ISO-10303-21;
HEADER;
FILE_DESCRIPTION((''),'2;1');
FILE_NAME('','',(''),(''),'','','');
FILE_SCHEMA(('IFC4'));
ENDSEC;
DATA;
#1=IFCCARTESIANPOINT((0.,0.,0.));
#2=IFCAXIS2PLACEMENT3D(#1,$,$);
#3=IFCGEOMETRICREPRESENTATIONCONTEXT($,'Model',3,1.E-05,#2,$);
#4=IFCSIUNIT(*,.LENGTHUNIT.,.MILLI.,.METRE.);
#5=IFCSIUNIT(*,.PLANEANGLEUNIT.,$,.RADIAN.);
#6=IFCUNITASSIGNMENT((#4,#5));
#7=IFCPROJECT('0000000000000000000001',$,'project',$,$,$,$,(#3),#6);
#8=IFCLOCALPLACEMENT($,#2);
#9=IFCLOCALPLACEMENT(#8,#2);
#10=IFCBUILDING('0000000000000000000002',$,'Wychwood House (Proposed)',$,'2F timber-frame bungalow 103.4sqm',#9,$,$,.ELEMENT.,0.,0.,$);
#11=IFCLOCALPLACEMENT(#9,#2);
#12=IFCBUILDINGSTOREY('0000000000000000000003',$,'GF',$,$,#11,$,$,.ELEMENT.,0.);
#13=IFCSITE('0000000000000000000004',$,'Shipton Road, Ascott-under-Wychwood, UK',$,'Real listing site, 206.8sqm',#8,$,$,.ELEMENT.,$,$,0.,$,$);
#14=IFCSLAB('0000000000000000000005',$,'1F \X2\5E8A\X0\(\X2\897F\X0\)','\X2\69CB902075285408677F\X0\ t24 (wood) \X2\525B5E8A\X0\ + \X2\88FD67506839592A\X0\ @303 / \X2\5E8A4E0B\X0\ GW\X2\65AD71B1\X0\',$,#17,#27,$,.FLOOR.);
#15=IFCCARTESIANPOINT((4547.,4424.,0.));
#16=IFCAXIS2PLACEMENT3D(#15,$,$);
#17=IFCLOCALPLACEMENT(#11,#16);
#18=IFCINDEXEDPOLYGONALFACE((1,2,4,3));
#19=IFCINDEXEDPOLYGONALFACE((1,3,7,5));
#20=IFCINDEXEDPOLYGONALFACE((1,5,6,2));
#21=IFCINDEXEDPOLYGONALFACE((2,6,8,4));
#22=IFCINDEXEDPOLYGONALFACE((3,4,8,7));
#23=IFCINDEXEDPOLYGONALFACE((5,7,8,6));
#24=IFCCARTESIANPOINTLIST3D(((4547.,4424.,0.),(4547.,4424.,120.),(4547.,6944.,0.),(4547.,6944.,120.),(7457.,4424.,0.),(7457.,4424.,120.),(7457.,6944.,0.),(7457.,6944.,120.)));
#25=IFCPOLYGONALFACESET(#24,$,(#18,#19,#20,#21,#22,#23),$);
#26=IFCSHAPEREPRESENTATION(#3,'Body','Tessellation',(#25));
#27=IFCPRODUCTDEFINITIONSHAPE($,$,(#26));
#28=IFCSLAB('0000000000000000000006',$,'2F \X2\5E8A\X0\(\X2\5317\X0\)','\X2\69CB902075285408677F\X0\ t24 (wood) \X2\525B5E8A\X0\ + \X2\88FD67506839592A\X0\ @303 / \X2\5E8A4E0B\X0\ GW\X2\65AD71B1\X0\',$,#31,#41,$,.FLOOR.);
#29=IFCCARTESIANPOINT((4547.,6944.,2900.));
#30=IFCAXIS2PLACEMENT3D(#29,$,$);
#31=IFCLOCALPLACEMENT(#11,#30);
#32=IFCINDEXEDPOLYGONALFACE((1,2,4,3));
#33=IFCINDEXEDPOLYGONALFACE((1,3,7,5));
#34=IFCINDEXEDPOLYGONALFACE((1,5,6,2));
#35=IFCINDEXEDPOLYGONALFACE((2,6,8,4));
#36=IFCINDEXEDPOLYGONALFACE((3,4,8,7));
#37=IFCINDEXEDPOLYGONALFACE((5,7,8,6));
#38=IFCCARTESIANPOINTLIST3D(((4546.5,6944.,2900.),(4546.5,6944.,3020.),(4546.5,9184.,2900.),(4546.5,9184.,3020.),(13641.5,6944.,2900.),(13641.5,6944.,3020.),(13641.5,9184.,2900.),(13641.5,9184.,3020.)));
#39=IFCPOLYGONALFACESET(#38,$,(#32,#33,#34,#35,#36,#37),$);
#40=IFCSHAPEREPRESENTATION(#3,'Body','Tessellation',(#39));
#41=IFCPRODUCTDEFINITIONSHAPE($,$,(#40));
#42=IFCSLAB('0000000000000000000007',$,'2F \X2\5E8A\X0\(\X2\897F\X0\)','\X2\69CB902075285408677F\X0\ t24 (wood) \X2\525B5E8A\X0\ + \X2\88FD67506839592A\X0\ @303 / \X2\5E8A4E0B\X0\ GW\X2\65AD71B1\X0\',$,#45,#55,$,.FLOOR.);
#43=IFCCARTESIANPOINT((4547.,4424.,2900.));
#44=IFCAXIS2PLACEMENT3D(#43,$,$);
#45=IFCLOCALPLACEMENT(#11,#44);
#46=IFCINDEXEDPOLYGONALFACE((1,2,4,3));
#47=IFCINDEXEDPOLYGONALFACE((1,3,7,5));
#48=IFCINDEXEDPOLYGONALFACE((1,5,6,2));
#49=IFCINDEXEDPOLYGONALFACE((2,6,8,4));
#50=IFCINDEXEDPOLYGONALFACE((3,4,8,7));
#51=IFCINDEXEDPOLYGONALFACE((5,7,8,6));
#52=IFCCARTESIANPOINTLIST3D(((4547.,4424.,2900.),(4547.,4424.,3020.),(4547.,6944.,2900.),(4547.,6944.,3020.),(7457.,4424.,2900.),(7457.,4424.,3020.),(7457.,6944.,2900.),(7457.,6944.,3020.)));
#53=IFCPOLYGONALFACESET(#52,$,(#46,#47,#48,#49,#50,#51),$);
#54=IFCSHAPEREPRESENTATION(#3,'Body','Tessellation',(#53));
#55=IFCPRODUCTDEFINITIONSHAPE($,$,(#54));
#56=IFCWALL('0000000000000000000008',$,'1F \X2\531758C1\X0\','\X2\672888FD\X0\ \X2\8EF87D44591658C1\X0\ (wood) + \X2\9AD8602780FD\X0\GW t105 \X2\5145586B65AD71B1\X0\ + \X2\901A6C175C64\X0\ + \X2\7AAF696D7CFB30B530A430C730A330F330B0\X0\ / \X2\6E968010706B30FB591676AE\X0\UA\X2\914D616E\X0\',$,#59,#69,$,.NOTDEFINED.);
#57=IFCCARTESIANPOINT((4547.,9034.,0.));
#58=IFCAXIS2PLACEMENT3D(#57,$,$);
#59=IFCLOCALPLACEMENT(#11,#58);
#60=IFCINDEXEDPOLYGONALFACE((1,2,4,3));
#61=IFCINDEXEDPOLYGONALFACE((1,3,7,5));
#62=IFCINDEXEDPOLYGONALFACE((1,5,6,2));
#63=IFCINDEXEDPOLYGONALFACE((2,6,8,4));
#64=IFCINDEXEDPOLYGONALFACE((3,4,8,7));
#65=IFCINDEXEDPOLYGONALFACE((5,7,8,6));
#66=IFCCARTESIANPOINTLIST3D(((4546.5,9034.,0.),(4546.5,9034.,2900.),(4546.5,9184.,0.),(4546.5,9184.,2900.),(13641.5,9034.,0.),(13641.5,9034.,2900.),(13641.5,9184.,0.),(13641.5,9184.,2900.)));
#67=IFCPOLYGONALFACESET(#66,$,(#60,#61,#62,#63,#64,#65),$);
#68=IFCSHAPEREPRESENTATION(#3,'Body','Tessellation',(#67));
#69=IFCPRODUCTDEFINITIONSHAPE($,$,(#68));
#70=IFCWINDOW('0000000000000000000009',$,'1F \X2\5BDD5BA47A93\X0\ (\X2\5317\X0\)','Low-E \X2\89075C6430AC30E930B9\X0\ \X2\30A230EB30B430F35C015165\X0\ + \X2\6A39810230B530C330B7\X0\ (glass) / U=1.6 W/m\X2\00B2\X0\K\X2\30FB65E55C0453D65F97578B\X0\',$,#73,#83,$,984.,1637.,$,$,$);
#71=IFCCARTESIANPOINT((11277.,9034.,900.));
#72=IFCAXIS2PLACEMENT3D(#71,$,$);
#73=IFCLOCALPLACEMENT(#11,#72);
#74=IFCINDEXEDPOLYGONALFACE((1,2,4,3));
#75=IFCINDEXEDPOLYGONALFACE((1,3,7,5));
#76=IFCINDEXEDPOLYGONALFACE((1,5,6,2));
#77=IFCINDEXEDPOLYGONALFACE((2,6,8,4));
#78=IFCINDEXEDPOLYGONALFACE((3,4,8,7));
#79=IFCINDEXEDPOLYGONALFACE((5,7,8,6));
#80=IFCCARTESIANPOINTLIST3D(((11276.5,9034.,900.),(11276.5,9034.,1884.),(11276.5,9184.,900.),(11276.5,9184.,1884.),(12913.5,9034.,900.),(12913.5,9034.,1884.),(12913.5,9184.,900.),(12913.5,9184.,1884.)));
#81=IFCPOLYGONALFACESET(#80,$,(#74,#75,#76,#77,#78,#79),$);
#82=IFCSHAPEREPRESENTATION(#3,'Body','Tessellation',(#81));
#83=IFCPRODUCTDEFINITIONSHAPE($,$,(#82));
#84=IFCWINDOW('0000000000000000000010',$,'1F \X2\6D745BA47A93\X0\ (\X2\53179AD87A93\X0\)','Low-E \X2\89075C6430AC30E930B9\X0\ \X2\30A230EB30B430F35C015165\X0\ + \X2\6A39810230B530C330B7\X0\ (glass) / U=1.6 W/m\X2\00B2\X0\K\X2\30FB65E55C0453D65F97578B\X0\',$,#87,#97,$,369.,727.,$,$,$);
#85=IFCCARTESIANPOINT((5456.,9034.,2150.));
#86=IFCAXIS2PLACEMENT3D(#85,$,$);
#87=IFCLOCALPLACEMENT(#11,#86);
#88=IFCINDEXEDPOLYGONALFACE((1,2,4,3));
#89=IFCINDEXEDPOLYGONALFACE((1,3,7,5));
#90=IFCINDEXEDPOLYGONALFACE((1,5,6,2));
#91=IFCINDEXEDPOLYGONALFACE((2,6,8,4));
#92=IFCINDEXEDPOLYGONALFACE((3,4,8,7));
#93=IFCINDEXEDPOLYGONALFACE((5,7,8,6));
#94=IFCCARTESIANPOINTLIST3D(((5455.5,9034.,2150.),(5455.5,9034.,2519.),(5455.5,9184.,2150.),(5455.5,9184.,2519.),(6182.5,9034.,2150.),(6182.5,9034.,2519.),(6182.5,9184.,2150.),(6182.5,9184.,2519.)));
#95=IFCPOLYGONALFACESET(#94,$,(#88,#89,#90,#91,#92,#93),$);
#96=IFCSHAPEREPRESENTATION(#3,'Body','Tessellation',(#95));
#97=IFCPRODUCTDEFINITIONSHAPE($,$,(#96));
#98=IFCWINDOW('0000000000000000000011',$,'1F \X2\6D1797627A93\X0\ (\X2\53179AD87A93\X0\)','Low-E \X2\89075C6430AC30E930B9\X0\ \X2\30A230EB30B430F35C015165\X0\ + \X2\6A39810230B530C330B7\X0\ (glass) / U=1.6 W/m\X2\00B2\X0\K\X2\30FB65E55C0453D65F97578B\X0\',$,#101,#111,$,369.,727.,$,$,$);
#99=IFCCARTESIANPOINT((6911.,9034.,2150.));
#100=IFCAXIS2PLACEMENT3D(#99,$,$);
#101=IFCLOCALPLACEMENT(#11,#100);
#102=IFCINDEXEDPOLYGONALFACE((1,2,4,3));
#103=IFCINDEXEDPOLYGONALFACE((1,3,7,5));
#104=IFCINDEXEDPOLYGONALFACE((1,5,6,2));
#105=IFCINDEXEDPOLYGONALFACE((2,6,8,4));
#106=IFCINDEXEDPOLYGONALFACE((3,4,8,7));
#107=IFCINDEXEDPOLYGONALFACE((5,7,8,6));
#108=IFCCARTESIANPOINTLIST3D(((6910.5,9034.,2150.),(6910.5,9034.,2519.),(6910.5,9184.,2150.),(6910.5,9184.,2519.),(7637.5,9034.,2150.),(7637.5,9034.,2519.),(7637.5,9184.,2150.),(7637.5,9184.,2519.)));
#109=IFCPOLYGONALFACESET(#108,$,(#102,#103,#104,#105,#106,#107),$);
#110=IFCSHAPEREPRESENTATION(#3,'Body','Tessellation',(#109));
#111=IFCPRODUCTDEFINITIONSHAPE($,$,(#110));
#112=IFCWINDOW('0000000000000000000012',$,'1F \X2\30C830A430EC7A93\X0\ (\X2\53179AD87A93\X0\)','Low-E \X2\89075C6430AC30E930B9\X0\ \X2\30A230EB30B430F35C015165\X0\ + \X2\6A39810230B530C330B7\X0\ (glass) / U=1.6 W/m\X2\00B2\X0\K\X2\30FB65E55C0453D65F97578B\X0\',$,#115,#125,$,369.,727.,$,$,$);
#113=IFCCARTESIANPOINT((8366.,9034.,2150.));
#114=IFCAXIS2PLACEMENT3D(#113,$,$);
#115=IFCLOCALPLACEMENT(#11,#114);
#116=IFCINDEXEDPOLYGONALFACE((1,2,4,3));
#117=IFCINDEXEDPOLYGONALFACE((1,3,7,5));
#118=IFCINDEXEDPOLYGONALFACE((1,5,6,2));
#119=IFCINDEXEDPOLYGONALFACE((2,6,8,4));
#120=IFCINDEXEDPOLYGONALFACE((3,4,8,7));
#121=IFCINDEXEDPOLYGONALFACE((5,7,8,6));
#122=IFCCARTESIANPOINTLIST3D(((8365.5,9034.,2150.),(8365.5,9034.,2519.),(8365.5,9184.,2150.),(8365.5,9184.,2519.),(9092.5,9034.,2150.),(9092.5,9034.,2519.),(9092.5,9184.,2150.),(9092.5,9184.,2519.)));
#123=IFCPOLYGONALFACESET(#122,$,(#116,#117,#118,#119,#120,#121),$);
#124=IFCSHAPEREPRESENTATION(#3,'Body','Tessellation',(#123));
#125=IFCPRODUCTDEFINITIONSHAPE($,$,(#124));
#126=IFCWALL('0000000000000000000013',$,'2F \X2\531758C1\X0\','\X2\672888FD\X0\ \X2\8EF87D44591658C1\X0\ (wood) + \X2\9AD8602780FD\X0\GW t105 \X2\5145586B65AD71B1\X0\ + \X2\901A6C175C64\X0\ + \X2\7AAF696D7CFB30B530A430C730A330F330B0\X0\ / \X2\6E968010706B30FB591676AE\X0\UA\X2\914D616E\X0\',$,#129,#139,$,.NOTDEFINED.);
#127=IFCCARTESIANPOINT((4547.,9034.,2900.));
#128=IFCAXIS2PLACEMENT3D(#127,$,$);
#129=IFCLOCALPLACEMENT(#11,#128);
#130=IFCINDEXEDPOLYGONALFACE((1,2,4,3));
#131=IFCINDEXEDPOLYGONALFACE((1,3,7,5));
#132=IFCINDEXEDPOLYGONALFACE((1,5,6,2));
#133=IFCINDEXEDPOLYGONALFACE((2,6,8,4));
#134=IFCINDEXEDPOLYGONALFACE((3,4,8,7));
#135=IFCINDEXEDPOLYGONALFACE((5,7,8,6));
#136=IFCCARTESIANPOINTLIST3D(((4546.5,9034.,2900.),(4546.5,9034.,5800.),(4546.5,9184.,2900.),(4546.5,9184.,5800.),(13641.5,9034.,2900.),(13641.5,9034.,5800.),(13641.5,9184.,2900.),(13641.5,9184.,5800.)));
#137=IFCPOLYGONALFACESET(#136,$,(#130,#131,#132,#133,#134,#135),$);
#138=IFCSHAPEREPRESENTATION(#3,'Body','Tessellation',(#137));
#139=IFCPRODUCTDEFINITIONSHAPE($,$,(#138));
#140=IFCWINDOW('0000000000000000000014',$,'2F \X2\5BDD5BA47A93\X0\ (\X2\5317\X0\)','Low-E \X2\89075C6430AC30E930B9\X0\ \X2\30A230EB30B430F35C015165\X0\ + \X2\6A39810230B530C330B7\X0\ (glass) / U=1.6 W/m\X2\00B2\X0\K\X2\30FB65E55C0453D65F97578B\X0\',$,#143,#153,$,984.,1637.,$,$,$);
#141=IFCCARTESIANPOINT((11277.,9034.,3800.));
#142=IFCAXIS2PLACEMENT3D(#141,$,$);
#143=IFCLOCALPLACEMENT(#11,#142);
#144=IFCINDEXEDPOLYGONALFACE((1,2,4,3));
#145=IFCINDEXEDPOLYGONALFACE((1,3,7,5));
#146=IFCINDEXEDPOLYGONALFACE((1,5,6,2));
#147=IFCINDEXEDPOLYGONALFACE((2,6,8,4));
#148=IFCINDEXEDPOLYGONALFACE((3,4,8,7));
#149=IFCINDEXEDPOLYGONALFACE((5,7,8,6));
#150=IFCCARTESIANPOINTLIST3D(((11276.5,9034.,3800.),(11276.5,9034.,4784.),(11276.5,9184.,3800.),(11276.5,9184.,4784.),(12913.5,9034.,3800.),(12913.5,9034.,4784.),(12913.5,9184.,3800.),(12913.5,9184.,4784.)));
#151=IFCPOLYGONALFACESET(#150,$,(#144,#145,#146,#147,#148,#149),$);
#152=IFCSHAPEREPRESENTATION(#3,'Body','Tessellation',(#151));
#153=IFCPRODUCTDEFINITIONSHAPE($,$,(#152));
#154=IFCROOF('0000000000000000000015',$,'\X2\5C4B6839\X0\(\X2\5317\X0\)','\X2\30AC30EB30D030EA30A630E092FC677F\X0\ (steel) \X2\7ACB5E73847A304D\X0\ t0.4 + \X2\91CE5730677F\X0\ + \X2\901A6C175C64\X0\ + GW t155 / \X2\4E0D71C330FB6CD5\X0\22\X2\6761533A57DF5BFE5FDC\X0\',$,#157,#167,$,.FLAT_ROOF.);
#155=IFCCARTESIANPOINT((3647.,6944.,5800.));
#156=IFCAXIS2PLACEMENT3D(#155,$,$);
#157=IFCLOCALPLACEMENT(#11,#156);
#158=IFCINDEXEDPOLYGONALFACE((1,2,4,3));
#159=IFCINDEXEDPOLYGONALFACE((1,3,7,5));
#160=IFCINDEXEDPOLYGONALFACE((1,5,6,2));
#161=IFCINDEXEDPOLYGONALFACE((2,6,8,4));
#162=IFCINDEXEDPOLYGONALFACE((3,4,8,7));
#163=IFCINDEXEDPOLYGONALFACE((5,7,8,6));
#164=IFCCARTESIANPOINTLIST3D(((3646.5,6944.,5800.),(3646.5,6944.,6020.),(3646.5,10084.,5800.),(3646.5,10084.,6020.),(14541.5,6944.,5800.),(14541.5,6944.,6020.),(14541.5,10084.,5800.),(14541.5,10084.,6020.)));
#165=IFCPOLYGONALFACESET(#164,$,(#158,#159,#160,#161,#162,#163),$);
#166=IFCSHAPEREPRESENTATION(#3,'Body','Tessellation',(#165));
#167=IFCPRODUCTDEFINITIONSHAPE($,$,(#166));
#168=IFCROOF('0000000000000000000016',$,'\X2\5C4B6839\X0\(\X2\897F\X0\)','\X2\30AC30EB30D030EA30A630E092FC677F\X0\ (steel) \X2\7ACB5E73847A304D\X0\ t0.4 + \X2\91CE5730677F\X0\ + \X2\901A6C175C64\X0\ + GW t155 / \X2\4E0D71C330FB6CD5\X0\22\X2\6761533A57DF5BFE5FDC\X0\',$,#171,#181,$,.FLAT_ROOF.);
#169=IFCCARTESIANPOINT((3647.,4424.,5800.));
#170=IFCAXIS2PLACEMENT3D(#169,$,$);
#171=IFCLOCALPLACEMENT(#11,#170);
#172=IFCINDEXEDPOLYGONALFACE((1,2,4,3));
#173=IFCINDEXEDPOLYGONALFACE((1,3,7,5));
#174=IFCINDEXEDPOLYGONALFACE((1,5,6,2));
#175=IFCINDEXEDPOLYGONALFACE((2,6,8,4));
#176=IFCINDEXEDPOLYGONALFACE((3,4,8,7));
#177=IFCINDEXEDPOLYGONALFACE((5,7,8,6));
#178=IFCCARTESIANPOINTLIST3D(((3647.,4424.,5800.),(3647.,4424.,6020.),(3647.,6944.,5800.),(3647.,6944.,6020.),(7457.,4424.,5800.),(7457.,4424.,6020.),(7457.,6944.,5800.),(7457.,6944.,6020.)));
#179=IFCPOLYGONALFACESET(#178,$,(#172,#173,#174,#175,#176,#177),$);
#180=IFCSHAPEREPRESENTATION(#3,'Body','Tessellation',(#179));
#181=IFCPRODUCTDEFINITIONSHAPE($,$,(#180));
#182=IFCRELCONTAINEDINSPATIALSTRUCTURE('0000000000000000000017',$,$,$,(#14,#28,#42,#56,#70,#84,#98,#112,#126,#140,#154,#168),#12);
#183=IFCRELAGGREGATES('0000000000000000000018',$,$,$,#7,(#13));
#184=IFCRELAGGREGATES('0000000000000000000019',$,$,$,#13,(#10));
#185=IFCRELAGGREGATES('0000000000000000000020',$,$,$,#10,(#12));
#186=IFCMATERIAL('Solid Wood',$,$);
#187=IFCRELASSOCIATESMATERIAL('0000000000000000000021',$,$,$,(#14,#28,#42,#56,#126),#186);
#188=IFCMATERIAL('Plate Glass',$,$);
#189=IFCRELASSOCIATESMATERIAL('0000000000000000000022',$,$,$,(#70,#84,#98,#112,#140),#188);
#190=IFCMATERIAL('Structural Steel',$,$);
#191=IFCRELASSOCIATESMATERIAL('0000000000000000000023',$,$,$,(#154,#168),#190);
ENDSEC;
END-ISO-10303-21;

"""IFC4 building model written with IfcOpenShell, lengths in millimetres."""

from ifc_helpers import new_model, si_unit, frame, frame_2d, origin, place, context, project, spatial, rectangle, extrude, material, element, fill, save


model = new_model("IFC4")

# Units and contexts
model_context = context("Model", 3, precision=1e-05, world=origin())
ifc_project = project(units=[si_unit("LENGTHUNIT", "METRE", prefix="MILLI"), si_unit("PLANEANGLEUNIT", "RADIAN")], contexts=[model_context])

# Site, building, storey
site_placement = place(None, origin())
site = spatial("IfcSite", under=ifc_project, at=site_placement, Name="Shipton Road, Ascott-under-Wychwood, UK", ObjectType="Real listing site, 206.8sqm", CompositionType="ELEMENT", RefElevation=0.0)
building_placement = place(site_placement, origin())
building = spatial("IfcBuilding", under=site, at=building_placement, Name="Wychwood House (Proposed)", ObjectType="2F timber-frame bungalow 103.4sqm", CompositionType="ELEMENT", ElevationOfRefHeight=0.0, ElevationOfTerrain=0.0)
storey_placement = place(building_placement, origin())
storey = spatial("IfcBuildingStorey", under=building, at=storey_placement, Name="GF", CompositionType="ELEMENT", Elevation=0.0)

# Slabs
ifc_material_1 = material(Name="Solid Wood")
slab_1_placement = place(storey_placement, frame((4547.0, 4424.0, 0.0)))
element("IfcSlab", 1, at=slab_1_placement, inside=storey, material=ifc_material_1, Name="1F 床(西)", Description="構造用合板 t24 (wood) 剛床 + 製材根太 @303 / 床下 GW断熱", PredefinedType="FLOOR", context=model_context, shape_type="SweptSolid", body=[
    extrude(rectangle(XDim=2910.0, YDim=2520.0, at=frame_2d((1455.0, 1260.0))), frame((4547.0, 4424.0, 0.0)), (0.0, 0.0, 1.0), 120.0),
])
slab_2_placement = place(storey_placement, frame((4547.0, 6944.0, 2900.0)))
element("IfcSlab", 2, at=slab_2_placement, inside=storey, material=ifc_material_1, Name="2F 床(北)", Description="構造用合板 t24 (wood) 剛床 + 製材根太 @303 / 床下 GW断熱", PredefinedType="FLOOR", context=model_context, shape_type="SweptSolid", body=[
    extrude(rectangle(XDim=9095.0, YDim=2240.0, at=frame_2d((4547.0, 1120.0))), frame((4547.0, 6944.0, 2900.0)), (0.0, 0.0, 1.0), 120.0),
])
slab_3_placement = place(storey_placement, frame((4547.0, 4424.0, 2900.0)))
element("IfcSlab", 3, at=slab_3_placement, inside=storey, material=ifc_material_1, Name="2F 床(西)", Description="構造用合板 t24 (wood) 剛床 + 製材根太 @303 / 床下 GW断熱", PredefinedType="FLOOR", context=model_context, shape_type="SweptSolid", body=[
    extrude(rectangle(XDim=2910.0, YDim=2520.0, at=frame_2d((1455.0, 1260.0))), frame((4547.0, 4424.0, 2900.0)), (0.0, 0.0, 1.0), 120.0),
])

# Wall, openings, windows
wall_1_placement = place(storey_placement, frame((4547.0, 9034.0, 0.0)))
wall_1 = element("IfcWall", 4, at=wall_1_placement, inside=storey, material=ifc_material_1, Name="1F 北壁", Description="木製 軸組外壁 (wood) + 高性能GW t105 充填断熱 + 通気層 + 窯業系サイディング / 準耐火・外皮UA配慮", PredefinedType="NOTDEFINED", context=model_context, shape_type="SweptSolid", body=[
    extrude(rectangle(XDim=9095.0, YDim=150.0, at=frame_2d((4547.0, 75.0))), frame((4547.0, 9034.0, 0.0)), (0.0, 0.0, 1.0), 2900.0),
])
opening_1_placement = place(storey_placement, frame((11277.0, 9034.0, 900.0)))
opening_1 = element("IfcOpeningElement", 5, at=opening_1_placement, cuts=wall_1, PredefinedType="NOTDEFINED", context=model_context, shape_type="SweptSolid", body=[
    extrude(rectangle(XDim=1637.0, YDim=150.0, at=frame_2d((818.0, 75.0))), frame((11277.0, 9034.0, 900.0)), (0.0, 0.0, 1.0), 984.0),
])
opening_2_placement = place(storey_placement, frame((5456.0, 9034.0, 2150.0)))
opening_2 = element("IfcOpeningElement", 6, at=opening_2_placement, cuts=wall_1, PredefinedType="NOTDEFINED", context=model_context, shape_type="SweptSolid", body=[
    extrude(rectangle(XDim=727.0, YDim=150.0, at=frame_2d((363.0, 75.0))), frame((5456.0, 9034.0, 2150.0)), (0.0, 0.0, 1.0), 369.0),
])
opening_3_placement = place(storey_placement, frame((6911.0, 9034.0, 2150.0)))
opening_3 = element("IfcOpeningElement", 7, at=opening_3_placement, cuts=wall_1, PredefinedType="NOTDEFINED", context=model_context, shape_type="SweptSolid", body=[
    extrude(rectangle(XDim=727.0, YDim=150.0, at=frame_2d((363.0, 75.0))), frame((6911.0, 9034.0, 2150.0)), (0.0, 0.0, 1.0), 369.0),
])
opening_4_placement = place(storey_placement, frame((8366.0, 9034.0, 2150.0)))
opening_4 = element("IfcOpeningElement", 8, at=opening_4_placement, cuts=wall_1, PredefinedType="NOTDEFINED", context=model_context, shape_type="SweptSolid", body=[
    extrude(rectangle(XDim=727.0, YDim=150.0, at=frame_2d((363.0, 75.0))), frame((8366.0, 9034.0, 2150.0)), (0.0, 0.0, 1.0), 369.0),
])
ifc_material_2 = material(Name="Plate Glass")
window_1_placement = place(storey_placement, frame((11277.0, 9034.0, 900.0)))
window_1 = element("IfcWindow", 9, at=window_1_placement, inside=storey, material=ifc_material_2, Name="1F 寝室窓 (北)", Description="Low-E 複層ガラス アルゴン封入 + 樹脂サッシ (glass) / U=1.6 W/m²K・日射取得型", OverallHeight=984.0, OverallWidth=1637.0, context=model_context, shape_type="SweptSolid", body=[
    extrude(rectangle(XDim=1637.0, YDim=150.0, at=frame_2d((818.0, 75.0))), frame((11277.0, 9034.0, 900.0)), (0.0, 0.0, 1.0), 984.0),
])
fill(opening_1, window_1)
window_2_placement = place(storey_placement, frame((5456.0, 9034.0, 2150.0)))
window_2 = element("IfcWindow", 10, at=window_2_placement, inside=storey, material=ifc_material_2, Name="1F 浴室窓 (北高窓)", Description="Low-E 複層ガラス アルゴン封入 + 樹脂サッシ (glass) / U=1.6 W/m²K・日射取得型", OverallHeight=369.0, OverallWidth=727.0, context=model_context, shape_type="SweptSolid", body=[
    extrude(rectangle(XDim=727.0, YDim=150.0, at=frame_2d((363.0, 75.0))), frame((5456.0, 9034.0, 2150.0)), (0.0, 0.0, 1.0), 369.0),
])
fill(opening_2, window_2)
window_3_placement = place(storey_placement, frame((6911.0, 9034.0, 2150.0)))
window_3 = element("IfcWindow", 11, at=window_3_placement, inside=storey, material=ifc_material_2, Name="1F 洗面窓 (北高窓)", Description="Low-E 複層ガラス アルゴン封入 + 樹脂サッシ (glass) / U=1.6 W/m²K・日射取得型", OverallHeight=369.0, OverallWidth=727.0, context=model_context, shape_type="SweptSolid", body=[
    extrude(rectangle(XDim=727.0, YDim=150.0, at=frame_2d((363.0, 75.0))), frame((6911.0, 9034.0, 2150.0)), (0.0, 0.0, 1.0), 369.0),
])
fill(opening_3, window_3)
window_4_placement = place(storey_placement, frame((8366.0, 9034.0, 2150.0)))
window_4 = element("IfcWindow", 12, at=window_4_placement, inside=storey, material=ifc_material_2, Name="1F トイレ窓 (北高窓)", Description="Low-E 複層ガラス アルゴン封入 + 樹脂サッシ (glass) / U=1.6 W/m²K・日射取得型", OverallHeight=369.0, OverallWidth=727.0, context=model_context, shape_type="SweptSolid", body=[
    extrude(rectangle(XDim=727.0, YDim=150.0, at=frame_2d((363.0, 75.0))), frame((8366.0, 9034.0, 2150.0)), (0.0, 0.0, 1.0), 369.0),
])
fill(opening_4, window_4)

# Wall, opening, window
wall_2_placement = place(storey_placement, frame((4547.0, 9034.0, 2900.0)))
wall_2 = element("IfcWall", 13, at=wall_2_placement, inside=storey, material=ifc_material_1, Name="2F 北壁", Description="木製 軸組外壁 (wood) + 高性能GW t105 充填断熱 + 通気層 + 窯業系サイディング / 準耐火・外皮UA配慮", PredefinedType="NOTDEFINED", context=model_context, shape_type="SweptSolid", body=[
    extrude(rectangle(XDim=9095.0, YDim=150.0, at=frame_2d((4547.0, 75.0))), frame((4547.0, 9034.0, 2900.0)), (0.0, 0.0, 1.0), 2900.0),
])
opening_5_placement = place(storey_placement, frame((11277.0, 9034.0, 3800.0)))
opening_5 = element("IfcOpeningElement", 14, at=opening_5_placement, cuts=wall_2, PredefinedType="NOTDEFINED", context=model_context, shape_type="SweptSolid", body=[
    extrude(rectangle(XDim=1637.0, YDim=150.0, at=frame_2d((818.0, 75.0))), frame((11277.0, 9034.0, 3800.0)), (0.0, 0.0, 1.0), 984.0),
])
window_5_placement = place(storey_placement, frame((11277.0, 9034.0, 3800.0)))
window_5 = element("IfcWindow", 15, at=window_5_placement, inside=storey, material=ifc_material_2, Name="2F 寝室窓 (北)", Description="Low-E 複層ガラス アルゴン封入 + 樹脂サッシ (glass) / U=1.6 W/m²K・日射取得型", OverallHeight=984.0, OverallWidth=1637.0, context=model_context, shape_type="SweptSolid", body=[
    extrude(rectangle(XDim=1637.0, YDim=150.0, at=frame_2d((818.0, 75.0))), frame((11277.0, 9034.0, 3800.0)), (0.0, 0.0, 1.0), 984.0),
])
fill(opening_5, window_5)

# Roofs
ifc_material_3 = material(Name="Structural Steel")
for number, where, name in (
    (16, (3647.0, 6944.0, 5800.0), "屋根(北)"),
):
    element("IfcRoof", number, at=place(storey_placement, frame(where)), inside=storey, material=ifc_material_3, Name=name, Description="ガルバリウム鋼板 (steel) 立平葺き t0.4 + 野地板 + 通気層 + GW t155 / 不燃・法22条区域対応", PredefinedType="FLAT_ROOF", context=model_context, shape_type="SweptSolid", body=[
        extrude(rectangle(XDim=10895.0, YDim=3140.0, at=frame_2d((5447.0, 1570.0))), frame((3647.0, 6944.0, 5800.0)), (0.0, 0.0, 1.0), 220.0),
    ])
roof_placement = place(storey_placement, frame((3647.0, 4424.0, 5800.0)))
element("IfcRoof", 17, at=roof_placement, inside=storey, material=ifc_material_3, Name="屋根(西)", Description="ガルバリウム鋼板 (steel) 立平葺き t0.4 + 野地板 + 通気層 + GW t155 / 不燃・法22条区域対応", PredefinedType="FLAT_ROOF", context=model_context, shape_type="SweptSolid", body=[
    extrude(rectangle(XDim=3810.0, YDim=2520.0, at=frame_2d((1905.0, 1260.0))), frame((3647.0, 4424.0, 5800.0)), (0.0, 0.0, 1.0), 220.0),
])

save(model, "model.ifc")
